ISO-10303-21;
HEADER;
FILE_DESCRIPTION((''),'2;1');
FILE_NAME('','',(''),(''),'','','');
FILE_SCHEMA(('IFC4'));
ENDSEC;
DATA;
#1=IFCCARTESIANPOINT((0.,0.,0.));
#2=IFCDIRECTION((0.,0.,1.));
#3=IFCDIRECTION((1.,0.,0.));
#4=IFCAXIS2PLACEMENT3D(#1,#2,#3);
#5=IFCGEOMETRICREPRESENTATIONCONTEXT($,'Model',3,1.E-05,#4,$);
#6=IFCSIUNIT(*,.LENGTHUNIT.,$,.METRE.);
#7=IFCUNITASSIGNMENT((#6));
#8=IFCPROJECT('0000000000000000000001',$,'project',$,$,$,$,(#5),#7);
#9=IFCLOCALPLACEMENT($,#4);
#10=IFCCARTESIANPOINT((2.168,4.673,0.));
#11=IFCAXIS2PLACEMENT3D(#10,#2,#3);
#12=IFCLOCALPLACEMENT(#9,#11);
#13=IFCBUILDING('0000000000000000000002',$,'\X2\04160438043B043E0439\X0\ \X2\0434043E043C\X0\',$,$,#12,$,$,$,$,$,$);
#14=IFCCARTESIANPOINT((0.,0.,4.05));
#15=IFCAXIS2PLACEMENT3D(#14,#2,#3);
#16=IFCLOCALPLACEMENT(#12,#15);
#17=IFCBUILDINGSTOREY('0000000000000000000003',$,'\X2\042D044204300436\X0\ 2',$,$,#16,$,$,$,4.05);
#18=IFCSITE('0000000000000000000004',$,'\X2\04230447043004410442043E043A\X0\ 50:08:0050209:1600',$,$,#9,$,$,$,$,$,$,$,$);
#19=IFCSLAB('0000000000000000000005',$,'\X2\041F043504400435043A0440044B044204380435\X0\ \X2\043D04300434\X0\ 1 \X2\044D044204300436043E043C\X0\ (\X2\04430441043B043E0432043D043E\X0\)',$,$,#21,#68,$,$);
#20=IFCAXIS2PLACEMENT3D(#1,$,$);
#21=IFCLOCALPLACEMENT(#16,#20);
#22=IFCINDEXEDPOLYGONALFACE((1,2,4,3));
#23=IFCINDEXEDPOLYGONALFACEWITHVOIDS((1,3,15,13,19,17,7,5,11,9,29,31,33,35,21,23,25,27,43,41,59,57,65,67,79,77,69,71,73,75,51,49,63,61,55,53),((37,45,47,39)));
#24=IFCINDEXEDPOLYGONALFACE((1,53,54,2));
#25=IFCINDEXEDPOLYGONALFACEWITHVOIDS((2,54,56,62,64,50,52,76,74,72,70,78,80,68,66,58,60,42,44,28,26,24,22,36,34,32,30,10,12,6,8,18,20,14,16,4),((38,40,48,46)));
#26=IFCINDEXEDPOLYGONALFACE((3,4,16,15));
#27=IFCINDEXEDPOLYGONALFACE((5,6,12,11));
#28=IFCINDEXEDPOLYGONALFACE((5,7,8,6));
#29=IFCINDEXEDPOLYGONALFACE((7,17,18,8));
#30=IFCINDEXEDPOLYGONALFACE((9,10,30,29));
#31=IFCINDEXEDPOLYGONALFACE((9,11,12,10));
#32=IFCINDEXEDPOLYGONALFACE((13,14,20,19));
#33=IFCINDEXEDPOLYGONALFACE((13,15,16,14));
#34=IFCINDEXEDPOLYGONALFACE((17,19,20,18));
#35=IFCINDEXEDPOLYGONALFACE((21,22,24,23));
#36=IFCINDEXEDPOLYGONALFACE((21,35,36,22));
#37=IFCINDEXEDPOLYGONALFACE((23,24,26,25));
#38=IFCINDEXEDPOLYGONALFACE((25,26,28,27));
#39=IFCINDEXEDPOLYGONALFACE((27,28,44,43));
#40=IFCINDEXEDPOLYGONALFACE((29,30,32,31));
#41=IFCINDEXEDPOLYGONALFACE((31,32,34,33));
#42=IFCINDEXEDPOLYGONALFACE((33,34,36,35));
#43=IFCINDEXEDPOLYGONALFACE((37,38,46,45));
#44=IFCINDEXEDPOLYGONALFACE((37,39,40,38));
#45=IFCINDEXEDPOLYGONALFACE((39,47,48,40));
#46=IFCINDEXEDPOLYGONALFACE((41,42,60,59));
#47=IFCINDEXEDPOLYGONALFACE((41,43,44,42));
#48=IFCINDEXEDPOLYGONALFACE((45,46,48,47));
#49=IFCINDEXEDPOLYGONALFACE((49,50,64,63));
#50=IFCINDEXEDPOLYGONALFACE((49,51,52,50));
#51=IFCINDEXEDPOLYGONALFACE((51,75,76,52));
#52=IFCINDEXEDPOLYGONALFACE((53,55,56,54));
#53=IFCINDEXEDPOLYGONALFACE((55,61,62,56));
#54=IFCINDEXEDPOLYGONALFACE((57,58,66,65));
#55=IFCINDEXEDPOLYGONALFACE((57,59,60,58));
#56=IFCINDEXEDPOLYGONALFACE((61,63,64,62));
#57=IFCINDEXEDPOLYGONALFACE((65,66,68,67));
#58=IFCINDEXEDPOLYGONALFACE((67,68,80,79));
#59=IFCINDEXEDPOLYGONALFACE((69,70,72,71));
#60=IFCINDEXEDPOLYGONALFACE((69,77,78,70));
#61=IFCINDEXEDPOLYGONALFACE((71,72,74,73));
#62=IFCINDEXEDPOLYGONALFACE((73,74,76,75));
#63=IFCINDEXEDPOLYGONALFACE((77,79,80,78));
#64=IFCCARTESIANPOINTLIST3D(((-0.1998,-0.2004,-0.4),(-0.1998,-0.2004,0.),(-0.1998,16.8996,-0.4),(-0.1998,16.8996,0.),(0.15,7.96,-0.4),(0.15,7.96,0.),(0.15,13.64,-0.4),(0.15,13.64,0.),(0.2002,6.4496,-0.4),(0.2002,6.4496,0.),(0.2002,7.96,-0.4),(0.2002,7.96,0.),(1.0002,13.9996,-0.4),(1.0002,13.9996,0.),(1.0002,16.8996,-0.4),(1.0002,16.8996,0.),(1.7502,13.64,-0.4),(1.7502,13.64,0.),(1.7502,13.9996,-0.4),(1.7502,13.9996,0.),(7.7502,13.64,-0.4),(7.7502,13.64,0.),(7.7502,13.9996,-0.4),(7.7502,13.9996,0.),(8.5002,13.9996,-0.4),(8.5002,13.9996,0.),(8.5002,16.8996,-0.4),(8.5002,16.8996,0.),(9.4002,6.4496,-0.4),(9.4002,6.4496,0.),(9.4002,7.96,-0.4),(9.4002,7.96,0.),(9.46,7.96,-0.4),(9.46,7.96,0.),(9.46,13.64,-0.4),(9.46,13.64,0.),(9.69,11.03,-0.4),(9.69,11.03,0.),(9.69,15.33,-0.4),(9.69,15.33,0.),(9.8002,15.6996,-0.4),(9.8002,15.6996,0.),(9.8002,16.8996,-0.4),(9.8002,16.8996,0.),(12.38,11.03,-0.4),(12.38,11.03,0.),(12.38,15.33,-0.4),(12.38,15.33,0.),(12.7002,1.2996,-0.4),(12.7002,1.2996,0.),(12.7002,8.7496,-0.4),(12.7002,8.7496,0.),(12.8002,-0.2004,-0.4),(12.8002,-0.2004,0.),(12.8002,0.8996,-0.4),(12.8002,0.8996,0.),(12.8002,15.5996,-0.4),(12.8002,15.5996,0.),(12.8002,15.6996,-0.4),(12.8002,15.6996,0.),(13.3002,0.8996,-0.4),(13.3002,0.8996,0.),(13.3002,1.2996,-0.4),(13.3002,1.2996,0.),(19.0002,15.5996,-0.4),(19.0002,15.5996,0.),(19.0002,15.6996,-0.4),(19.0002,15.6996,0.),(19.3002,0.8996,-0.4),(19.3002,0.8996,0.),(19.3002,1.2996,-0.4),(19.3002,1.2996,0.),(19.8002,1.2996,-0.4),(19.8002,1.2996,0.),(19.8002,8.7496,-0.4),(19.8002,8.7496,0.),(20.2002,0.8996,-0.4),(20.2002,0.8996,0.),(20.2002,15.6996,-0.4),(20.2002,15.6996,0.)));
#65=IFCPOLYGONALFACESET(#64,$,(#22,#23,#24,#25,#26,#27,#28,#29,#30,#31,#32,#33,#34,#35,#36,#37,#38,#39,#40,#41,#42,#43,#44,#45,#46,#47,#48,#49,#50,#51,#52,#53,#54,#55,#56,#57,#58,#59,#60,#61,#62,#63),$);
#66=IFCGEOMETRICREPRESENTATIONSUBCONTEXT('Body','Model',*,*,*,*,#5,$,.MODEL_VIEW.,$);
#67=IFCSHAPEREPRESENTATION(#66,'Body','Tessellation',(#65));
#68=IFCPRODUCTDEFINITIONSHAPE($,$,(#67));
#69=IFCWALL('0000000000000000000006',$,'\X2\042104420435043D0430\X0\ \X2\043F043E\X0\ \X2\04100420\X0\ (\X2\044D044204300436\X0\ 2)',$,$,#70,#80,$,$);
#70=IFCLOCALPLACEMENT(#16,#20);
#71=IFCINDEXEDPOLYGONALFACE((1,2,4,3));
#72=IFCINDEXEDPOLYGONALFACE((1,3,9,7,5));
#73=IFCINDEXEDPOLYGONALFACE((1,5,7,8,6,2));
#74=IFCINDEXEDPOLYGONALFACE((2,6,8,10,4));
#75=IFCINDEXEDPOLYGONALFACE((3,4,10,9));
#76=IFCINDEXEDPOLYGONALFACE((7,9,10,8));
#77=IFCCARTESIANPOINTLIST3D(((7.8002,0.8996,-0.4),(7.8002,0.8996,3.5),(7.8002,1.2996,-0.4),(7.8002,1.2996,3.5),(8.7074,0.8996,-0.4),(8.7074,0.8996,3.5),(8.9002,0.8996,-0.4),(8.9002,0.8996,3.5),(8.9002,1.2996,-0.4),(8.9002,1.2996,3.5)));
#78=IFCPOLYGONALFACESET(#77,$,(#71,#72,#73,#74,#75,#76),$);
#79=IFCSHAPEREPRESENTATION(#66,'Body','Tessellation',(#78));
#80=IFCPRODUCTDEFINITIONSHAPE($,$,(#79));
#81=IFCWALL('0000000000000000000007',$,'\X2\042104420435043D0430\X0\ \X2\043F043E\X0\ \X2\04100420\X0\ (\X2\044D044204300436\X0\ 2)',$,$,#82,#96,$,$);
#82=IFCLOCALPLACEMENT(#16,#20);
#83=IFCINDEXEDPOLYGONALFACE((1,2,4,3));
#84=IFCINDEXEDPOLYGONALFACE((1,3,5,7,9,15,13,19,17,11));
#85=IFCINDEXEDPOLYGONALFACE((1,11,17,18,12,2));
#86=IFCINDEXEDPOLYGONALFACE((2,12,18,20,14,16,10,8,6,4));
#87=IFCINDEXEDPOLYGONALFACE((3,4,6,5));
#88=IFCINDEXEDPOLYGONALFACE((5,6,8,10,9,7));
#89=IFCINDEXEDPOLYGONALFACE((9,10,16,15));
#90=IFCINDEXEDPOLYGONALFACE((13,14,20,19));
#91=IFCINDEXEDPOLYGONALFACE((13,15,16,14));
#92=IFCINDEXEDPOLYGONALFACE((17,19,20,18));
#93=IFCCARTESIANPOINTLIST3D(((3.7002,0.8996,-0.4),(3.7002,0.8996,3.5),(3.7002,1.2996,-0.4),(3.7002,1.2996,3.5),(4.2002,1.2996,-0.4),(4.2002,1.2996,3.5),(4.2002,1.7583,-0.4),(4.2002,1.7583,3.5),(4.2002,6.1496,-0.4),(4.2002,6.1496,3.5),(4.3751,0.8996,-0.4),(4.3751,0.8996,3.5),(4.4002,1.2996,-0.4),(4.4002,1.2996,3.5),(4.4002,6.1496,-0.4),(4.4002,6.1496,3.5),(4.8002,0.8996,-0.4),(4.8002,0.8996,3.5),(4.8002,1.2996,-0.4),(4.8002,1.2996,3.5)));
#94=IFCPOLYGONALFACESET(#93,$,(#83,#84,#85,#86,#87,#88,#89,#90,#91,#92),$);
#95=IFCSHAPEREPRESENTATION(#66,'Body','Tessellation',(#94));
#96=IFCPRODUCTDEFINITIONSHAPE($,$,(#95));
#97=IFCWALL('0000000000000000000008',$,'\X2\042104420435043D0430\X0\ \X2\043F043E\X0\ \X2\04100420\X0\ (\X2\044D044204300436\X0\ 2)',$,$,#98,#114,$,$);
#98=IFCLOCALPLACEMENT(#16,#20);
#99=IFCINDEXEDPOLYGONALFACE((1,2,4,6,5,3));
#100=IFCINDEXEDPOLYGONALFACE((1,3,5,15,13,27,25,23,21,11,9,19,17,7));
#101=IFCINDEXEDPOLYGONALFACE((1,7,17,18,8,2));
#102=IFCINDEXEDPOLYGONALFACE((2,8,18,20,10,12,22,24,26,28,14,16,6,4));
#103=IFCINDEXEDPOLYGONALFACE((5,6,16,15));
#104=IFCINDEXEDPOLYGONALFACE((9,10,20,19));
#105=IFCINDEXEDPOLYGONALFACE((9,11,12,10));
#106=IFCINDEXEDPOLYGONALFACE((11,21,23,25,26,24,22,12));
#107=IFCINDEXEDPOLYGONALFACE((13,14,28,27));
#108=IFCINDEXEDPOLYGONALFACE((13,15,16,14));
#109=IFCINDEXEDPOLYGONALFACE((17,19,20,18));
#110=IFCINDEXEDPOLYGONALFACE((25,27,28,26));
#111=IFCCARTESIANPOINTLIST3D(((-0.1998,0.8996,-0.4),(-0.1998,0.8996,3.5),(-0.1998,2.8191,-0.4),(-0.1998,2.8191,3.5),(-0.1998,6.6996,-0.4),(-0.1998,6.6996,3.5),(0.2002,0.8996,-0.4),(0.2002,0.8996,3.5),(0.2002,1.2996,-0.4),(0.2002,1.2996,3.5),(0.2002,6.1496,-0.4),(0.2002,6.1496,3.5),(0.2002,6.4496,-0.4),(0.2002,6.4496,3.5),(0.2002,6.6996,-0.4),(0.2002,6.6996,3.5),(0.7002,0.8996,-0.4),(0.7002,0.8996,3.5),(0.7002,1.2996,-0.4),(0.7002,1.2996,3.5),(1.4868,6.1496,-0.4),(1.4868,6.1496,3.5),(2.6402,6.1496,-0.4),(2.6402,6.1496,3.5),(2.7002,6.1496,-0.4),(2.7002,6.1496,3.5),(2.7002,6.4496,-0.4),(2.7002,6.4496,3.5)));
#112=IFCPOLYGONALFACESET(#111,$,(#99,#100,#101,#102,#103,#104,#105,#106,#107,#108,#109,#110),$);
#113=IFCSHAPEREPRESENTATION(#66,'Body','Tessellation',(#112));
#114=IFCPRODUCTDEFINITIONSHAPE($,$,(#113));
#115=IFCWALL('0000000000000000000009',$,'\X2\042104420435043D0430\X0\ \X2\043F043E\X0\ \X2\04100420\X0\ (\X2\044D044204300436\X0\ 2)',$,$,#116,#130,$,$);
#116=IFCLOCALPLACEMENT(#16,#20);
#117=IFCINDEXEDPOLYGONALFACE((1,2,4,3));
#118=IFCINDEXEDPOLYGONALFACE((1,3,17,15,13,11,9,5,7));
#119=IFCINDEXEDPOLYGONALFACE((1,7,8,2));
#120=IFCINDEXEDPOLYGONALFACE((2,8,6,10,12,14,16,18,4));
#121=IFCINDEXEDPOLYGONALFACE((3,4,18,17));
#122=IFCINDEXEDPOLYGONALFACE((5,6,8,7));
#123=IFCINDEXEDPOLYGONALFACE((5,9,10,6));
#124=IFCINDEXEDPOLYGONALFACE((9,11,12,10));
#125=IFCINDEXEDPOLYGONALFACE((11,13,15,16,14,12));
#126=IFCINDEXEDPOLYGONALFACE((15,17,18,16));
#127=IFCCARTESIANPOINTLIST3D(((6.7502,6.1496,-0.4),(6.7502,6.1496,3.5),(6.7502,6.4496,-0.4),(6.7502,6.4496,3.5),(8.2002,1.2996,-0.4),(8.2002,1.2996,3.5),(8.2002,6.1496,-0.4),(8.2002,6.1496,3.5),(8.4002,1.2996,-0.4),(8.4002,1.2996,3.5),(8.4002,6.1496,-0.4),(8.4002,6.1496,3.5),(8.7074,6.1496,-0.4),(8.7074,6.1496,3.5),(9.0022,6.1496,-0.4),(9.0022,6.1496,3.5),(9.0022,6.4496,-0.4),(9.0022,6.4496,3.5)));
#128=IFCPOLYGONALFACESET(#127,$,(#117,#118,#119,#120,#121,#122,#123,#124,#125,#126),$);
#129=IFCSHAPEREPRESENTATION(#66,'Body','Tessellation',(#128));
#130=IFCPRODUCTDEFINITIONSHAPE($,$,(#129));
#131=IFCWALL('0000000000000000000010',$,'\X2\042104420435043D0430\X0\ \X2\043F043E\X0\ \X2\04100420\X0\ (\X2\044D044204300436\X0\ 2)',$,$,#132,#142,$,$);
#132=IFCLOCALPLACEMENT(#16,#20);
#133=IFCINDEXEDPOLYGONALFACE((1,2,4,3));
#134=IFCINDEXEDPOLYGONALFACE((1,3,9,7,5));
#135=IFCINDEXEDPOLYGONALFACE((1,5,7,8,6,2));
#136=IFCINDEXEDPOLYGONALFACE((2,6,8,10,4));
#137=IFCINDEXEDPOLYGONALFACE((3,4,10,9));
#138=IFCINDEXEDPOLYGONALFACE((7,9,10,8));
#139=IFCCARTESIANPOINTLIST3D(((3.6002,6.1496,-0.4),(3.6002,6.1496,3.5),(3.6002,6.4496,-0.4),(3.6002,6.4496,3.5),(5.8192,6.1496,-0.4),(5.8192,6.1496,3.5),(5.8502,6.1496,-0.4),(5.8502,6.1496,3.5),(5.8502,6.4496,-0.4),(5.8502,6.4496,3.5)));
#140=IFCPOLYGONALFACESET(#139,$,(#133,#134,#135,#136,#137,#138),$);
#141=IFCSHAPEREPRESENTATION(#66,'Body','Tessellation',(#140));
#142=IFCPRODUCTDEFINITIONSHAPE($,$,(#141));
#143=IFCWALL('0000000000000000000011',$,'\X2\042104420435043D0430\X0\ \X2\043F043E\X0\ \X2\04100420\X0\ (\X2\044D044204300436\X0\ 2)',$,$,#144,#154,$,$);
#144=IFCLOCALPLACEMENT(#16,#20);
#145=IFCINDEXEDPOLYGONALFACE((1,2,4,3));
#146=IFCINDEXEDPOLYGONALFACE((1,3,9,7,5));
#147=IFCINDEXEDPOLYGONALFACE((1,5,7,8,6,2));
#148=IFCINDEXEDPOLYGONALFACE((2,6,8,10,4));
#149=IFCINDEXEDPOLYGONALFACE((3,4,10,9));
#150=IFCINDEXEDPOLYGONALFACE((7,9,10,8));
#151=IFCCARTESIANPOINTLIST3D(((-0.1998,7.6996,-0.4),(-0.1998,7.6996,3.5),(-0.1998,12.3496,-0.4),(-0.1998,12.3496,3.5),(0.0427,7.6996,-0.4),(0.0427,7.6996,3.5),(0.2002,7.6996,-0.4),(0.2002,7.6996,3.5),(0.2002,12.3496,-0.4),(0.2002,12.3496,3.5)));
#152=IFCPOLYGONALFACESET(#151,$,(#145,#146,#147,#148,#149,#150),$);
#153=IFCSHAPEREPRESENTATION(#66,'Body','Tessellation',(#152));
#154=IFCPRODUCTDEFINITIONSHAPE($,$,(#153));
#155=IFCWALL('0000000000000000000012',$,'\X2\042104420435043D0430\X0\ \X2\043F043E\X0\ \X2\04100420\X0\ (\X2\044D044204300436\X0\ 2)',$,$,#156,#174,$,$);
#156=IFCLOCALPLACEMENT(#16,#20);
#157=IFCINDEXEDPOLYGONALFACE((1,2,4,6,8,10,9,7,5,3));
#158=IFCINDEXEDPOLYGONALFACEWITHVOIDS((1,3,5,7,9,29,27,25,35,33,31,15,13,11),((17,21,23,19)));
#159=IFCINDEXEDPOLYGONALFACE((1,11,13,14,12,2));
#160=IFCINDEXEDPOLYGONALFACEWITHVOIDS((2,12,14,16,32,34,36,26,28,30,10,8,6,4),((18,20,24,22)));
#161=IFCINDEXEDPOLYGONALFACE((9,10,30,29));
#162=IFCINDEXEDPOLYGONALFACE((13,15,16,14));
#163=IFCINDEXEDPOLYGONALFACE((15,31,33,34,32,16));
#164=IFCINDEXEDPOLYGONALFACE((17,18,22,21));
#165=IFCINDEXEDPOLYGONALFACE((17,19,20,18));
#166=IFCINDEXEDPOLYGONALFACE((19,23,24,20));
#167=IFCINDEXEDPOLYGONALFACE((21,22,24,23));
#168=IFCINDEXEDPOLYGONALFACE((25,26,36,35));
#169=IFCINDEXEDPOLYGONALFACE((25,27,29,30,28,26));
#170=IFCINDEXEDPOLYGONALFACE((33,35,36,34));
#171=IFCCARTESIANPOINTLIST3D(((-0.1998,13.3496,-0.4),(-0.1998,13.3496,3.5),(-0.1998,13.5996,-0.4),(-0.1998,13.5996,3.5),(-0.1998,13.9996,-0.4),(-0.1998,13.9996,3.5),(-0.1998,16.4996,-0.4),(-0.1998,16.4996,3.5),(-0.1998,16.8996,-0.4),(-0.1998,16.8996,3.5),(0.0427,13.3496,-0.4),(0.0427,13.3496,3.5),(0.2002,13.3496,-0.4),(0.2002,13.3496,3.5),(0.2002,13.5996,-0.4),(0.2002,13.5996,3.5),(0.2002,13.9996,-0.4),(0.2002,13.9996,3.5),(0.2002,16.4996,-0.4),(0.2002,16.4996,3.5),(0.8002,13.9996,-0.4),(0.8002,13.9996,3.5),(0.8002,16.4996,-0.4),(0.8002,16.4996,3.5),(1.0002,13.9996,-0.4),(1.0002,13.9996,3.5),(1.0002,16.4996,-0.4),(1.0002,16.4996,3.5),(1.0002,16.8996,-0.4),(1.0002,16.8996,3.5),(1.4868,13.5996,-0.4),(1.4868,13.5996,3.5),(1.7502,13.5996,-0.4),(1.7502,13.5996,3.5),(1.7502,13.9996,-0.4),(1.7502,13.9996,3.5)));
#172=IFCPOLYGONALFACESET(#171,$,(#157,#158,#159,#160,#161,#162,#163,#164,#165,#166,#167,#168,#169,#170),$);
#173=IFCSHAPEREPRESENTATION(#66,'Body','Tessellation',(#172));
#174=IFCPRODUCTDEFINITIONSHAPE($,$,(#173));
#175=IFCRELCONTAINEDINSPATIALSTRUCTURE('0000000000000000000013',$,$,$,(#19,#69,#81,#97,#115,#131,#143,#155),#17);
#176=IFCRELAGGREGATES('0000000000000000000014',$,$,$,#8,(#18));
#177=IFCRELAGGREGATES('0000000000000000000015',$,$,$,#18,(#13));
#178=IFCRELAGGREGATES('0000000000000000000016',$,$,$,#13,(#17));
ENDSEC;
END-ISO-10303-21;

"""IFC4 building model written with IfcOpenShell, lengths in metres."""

from ifc_helpers import new_model, si_unit, frame, origin_with_axes, place, context, subcontext, project, spatial, polyline, outline, extrude, element, save


model = new_model("IFC4")

# Units and contexts
model_context = context("Model", 3, precision=1e-05, world=origin_with_axes())
body_context = subcontext(model_context, "Body", "Model", "MODEL_VIEW")
ifc_project = project(units=[si_unit("LENGTHUNIT", "METRE")], contexts=[model_context])

# Site, building, storey
site_placement = place(None, origin_with_axes())
site = spatial("IfcSite", under=ifc_project, at=site_placement, Name="Участок 50:08:0050209:1600")
building_placement = place(site_placement, frame((2.168, 4.673, 0.0), z_axis=(0.0, 0.0, 1.0), x_axis=(1.0, 0.0, 0.0)))
building = spatial("IfcBuilding", under=site, at=building_placement, Name="Жилой дом")
storey_placement = place(building_placement, frame((0.0, 0.0, 4.05), z_axis=(0.0, 0.0, 1.0), x_axis=(1.0, 0.0, 0.0)))
storey = spatial("IfcBuildingStorey", under=building, at=storey_placement, Name="Этаж 2", Elevation=4.05)

# Slab
slab_placement = place(storey_placement, frame((0.0, 0.0, -4.05), z_axis=(0.0, 0.0, 1.0), x_axis=(1.0, 0.0, 0.0)))
element("IfcSlab", 1, at=slab_placement, inside=storey, Name="Перекрытие над 1 этажом (условно)", context=body_context, shape_type="SweptSolid", body=[
    extrude(outline(polyline([(1.0002, 16.8996), (1.0002, 13.9996), (1.7502, 13.9996), (1.7502, 13.64), (0.15, 13.64), (0.15, 7.96), (0.2002, 7.96), (0.2002, 6.4496), (9.4002, 6.4496), (9.4002, 7.96), (9.46, 7.96), (9.46, 13.64), (7.7502, 13.64), (7.7502, 13.9996), (8.5002, 13.9996), (8.5002, 16.8996), (9.8002, 16.8996), (9.8002, 15.6996), (12.8002, 15.6996), (12.8002, 15.5996), (19.0002, 15.5996), (19.0002, 15.6996), (20.2002, 15.6996), (20.2002, 0.8996), (19.3002, 0.8996), (19.3002, 1.2996), (19.8002, 1.2996), (19.8002, 8.7496), (12.7002, 8.7496), (12.7002, 1.2996), (13.3002, 1.2996), (13.3002, 0.8996), (12.8002, 0.8996), (12.8002, -0.2004), (-0.1998, -0.2004), (-0.1998, 16.8996), (1.0002, 16.8996)]), holes=[polyline([(12.38, 11.03), (12.38, 15.33), (9.69, 15.33), (9.69, 11.03), (12.38, 11.03)])]), frame((0.0, 0.0, 3.65), z_axis=(0.0, 0.0, 1.0), x_axis=(1.0, 0.0, 0.0)), (0.0, 0.0, 1.0), 0.4),
])

# Walls
wall_1_placement = place(storey_placement, frame((0.0, 0.0, -4.05), z_axis=(0.0, 0.0, 1.0), x_axis=(1.0, 0.0, 0.0)))
element("IfcWall", 2, at=wall_1_placement, inside=storey, Name="Стена по АР (этаж 2)", context=body_context, shape_type="SweptSolid", body=[
    extrude(outline(polyline([(8.9002, 0.8996), (8.7074, 0.8996), (7.8002, 0.8996), (7.8002, 1.2996), (8.9002, 1.2996), (8.9002, 0.8996)])), frame((0.0, 0.0, 3.65), z_axis=(0.0, 0.0, 1.0), x_axis=(1.0, 0.0, 0.0)), (0.0, 0.0, 1.0), 3.9),
])
wall_2_placement = place(storey_placement, frame((0.0, 0.0, -4.05), z_axis=(0.0, 0.0, 1.0), x_axis=(1.0, 0.0, 0.0)))
element("IfcWall", 3, at=wall_2_placement, inside=storey, Name="Стена по АР (этаж 2)", context=body_context, shape_type="SweptSolid", body=[
    extrude(outline(polyline([(4.2002, 1.7583), (4.2002, 6.1496), (4.4002, 6.1496), (4.4002, 1.2996), (4.8002, 1.2996), (4.8002, 0.8996), (4.3751, 0.8996), (3.7002, 0.8996), (3.7002, 1.2996), (4.2002, 1.2996), (4.2002, 1.7583)])), frame((0.0, 0.0, 3.65), z_axis=(0.0, 0.0, 1.0), x_axis=(1.0, 0.0, 0.0)), (0.0, 0.0, 1.0), 3.9),
])
wall_3_placement = place(storey_placement, frame((0.0, 0.0, -4.05), z_axis=(0.0, 0.0, 1.0), x_axis=(1.0, 0.0, 0.0)))
element("IfcWall", 4, at=wall_3_placement, inside=storey, Name="Стена по АР (этаж 2)", context=body_context, shape_type="SweptSolid", body=[
    extrude(outline(polyline([(0.2002, 0.8996), (0.2002, 0.8996), (-0.1998, 0.8996), (-0.1998, 2.8191), (-0.1998, 6.6996), (0.2002, 6.6996), (0.2002, 6.4496), (2.7002, 6.4496), (2.7002, 6.1496), (2.6402, 6.1496), (1.4868, 6.1496), (0.2002, 6.1496), (0.2002, 1.2996), (0.7002, 1.2996), (0.7002, 0.8996), (0.2002, 0.8996)])), frame((0.0, 0.0, 3.65), z_axis=(0.0, 0.0, 1.0), x_axis=(1.0, 0.0, 0.0)), (0.0, 0.0, 1.0), 3.9),
])
wall_4_placement = place(storey_placement, frame((0.0, 0.0, -4.05), z_axis=(0.0, 0.0, 1.0), x_axis=(1.0, 0.0, 0.0)))
element("IfcWall", 5, at=wall_4_placement, inside=storey, Name="Стена по АР (этаж 2)", context=body_context, shape_type="SweptSolid", body=[
    extrude(outline(polyline([(8.2002, 6.1496), (6.7502, 6.1496), (6.7502, 6.4496), (9.0022, 6.4496), (9.0022, 6.1496), (8.7074, 6.1496), (8.4002, 6.1496), (8.4002, 6.1496), (8.4002, 1.2996), (8.2002, 1.2996), (8.2002, 6.1496)])), frame((0.0, 0.0, 3.65), z_axis=(0.0, 0.0, 1.0), x_axis=(1.0, 0.0, 0.0)), (0.0, 0.0, 1.0), 3.9),
])
wall_5_placement = place(storey_placement, frame((0.0, 0.0, -4.05), z_axis=(0.0, 0.0, 1.0), x_axis=(1.0, 0.0, 0.0)))
element("IfcWall", 6, at=wall_5_placement, inside=storey, Name="Стена по АР (этаж 2)", context=body_context, shape_type="SweptSolid", body=[
    extrude(outline(polyline([(5.8192, 6.1496), (3.6002, 6.1496), (3.6002, 6.4496), (5.8502, 6.4496), (5.8502, 6.1496), (5.8192, 6.1496)])), frame((0.0, 0.0, 3.65), z_axis=(0.0, 0.0, 1.0), x_axis=(1.0, 0.0, 0.0)), (0.0, 0.0, 1.0), 3.9),
])
wall_6_placement = place(storey_placement, frame((0.0, 0.0, -4.05), z_axis=(0.0, 0.0, 1.0), x_axis=(1.0, 0.0, 0.0)))
element("IfcWall", 7, at=wall_6_placement, inside=storey, Name="Стена по АР (этаж 2)", context=body_context, shape_type="SweptSolid", body=[
    extrude(outline(polyline([(0.0427, 7.6996), (-0.1998, 7.6996), (-0.1998, 12.3496), (0.2002, 12.3496), (0.2002, 7.6996), (0.0427, 7.6996)])), frame((0.0, 0.0, 3.65), z_axis=(0.0, 0.0, 1.0), x_axis=(1.0, 0.0, 0.0)), (0.0, 0.0, 1.0), 3.9),
])
wall_7_placement = place(storey_placement, frame((0.0, 0.0, -4.05), z_axis=(0.0, 0.0, 1.0), x_axis=(1.0, 0.0, 0.0)))
element("IfcWall", 8, at=wall_7_placement, inside=storey, Name="Стена по АР (этаж 2)", context=body_context, shape_type="SweptSolid", body=[
    extrude(outline(polyline([(0.0427, 13.3496), (-0.1998, 13.3496), (-0.1998, 13.5996), (-0.1998, 13.9996), (-0.1998, 13.9996), (-0.1998, 16.4996), (-0.1998, 16.8996), (1.0002, 16.8996), (1.0002, 16.4996), (1.0002, 13.9996), (1.7502, 13.9996), (1.7502, 13.5996), (1.4868, 13.5996), (0.2002, 13.5996), (0.2002, 13.3496), (0.0427, 13.3496)]), holes=[polyline([(0.2002, 16.4996), (0.2002, 13.9996), (0.8002, 13.9996), (0.8002, 16.4996), (0.2002, 16.4996)])]), frame((0.0, 0.0, 3.65), z_axis=(0.0, 0.0, 1.0), x_axis=(1.0, 0.0, 0.0)), (0.0, 0.0, 1.0), 3.9),
])

save(model, "model.ifc")
